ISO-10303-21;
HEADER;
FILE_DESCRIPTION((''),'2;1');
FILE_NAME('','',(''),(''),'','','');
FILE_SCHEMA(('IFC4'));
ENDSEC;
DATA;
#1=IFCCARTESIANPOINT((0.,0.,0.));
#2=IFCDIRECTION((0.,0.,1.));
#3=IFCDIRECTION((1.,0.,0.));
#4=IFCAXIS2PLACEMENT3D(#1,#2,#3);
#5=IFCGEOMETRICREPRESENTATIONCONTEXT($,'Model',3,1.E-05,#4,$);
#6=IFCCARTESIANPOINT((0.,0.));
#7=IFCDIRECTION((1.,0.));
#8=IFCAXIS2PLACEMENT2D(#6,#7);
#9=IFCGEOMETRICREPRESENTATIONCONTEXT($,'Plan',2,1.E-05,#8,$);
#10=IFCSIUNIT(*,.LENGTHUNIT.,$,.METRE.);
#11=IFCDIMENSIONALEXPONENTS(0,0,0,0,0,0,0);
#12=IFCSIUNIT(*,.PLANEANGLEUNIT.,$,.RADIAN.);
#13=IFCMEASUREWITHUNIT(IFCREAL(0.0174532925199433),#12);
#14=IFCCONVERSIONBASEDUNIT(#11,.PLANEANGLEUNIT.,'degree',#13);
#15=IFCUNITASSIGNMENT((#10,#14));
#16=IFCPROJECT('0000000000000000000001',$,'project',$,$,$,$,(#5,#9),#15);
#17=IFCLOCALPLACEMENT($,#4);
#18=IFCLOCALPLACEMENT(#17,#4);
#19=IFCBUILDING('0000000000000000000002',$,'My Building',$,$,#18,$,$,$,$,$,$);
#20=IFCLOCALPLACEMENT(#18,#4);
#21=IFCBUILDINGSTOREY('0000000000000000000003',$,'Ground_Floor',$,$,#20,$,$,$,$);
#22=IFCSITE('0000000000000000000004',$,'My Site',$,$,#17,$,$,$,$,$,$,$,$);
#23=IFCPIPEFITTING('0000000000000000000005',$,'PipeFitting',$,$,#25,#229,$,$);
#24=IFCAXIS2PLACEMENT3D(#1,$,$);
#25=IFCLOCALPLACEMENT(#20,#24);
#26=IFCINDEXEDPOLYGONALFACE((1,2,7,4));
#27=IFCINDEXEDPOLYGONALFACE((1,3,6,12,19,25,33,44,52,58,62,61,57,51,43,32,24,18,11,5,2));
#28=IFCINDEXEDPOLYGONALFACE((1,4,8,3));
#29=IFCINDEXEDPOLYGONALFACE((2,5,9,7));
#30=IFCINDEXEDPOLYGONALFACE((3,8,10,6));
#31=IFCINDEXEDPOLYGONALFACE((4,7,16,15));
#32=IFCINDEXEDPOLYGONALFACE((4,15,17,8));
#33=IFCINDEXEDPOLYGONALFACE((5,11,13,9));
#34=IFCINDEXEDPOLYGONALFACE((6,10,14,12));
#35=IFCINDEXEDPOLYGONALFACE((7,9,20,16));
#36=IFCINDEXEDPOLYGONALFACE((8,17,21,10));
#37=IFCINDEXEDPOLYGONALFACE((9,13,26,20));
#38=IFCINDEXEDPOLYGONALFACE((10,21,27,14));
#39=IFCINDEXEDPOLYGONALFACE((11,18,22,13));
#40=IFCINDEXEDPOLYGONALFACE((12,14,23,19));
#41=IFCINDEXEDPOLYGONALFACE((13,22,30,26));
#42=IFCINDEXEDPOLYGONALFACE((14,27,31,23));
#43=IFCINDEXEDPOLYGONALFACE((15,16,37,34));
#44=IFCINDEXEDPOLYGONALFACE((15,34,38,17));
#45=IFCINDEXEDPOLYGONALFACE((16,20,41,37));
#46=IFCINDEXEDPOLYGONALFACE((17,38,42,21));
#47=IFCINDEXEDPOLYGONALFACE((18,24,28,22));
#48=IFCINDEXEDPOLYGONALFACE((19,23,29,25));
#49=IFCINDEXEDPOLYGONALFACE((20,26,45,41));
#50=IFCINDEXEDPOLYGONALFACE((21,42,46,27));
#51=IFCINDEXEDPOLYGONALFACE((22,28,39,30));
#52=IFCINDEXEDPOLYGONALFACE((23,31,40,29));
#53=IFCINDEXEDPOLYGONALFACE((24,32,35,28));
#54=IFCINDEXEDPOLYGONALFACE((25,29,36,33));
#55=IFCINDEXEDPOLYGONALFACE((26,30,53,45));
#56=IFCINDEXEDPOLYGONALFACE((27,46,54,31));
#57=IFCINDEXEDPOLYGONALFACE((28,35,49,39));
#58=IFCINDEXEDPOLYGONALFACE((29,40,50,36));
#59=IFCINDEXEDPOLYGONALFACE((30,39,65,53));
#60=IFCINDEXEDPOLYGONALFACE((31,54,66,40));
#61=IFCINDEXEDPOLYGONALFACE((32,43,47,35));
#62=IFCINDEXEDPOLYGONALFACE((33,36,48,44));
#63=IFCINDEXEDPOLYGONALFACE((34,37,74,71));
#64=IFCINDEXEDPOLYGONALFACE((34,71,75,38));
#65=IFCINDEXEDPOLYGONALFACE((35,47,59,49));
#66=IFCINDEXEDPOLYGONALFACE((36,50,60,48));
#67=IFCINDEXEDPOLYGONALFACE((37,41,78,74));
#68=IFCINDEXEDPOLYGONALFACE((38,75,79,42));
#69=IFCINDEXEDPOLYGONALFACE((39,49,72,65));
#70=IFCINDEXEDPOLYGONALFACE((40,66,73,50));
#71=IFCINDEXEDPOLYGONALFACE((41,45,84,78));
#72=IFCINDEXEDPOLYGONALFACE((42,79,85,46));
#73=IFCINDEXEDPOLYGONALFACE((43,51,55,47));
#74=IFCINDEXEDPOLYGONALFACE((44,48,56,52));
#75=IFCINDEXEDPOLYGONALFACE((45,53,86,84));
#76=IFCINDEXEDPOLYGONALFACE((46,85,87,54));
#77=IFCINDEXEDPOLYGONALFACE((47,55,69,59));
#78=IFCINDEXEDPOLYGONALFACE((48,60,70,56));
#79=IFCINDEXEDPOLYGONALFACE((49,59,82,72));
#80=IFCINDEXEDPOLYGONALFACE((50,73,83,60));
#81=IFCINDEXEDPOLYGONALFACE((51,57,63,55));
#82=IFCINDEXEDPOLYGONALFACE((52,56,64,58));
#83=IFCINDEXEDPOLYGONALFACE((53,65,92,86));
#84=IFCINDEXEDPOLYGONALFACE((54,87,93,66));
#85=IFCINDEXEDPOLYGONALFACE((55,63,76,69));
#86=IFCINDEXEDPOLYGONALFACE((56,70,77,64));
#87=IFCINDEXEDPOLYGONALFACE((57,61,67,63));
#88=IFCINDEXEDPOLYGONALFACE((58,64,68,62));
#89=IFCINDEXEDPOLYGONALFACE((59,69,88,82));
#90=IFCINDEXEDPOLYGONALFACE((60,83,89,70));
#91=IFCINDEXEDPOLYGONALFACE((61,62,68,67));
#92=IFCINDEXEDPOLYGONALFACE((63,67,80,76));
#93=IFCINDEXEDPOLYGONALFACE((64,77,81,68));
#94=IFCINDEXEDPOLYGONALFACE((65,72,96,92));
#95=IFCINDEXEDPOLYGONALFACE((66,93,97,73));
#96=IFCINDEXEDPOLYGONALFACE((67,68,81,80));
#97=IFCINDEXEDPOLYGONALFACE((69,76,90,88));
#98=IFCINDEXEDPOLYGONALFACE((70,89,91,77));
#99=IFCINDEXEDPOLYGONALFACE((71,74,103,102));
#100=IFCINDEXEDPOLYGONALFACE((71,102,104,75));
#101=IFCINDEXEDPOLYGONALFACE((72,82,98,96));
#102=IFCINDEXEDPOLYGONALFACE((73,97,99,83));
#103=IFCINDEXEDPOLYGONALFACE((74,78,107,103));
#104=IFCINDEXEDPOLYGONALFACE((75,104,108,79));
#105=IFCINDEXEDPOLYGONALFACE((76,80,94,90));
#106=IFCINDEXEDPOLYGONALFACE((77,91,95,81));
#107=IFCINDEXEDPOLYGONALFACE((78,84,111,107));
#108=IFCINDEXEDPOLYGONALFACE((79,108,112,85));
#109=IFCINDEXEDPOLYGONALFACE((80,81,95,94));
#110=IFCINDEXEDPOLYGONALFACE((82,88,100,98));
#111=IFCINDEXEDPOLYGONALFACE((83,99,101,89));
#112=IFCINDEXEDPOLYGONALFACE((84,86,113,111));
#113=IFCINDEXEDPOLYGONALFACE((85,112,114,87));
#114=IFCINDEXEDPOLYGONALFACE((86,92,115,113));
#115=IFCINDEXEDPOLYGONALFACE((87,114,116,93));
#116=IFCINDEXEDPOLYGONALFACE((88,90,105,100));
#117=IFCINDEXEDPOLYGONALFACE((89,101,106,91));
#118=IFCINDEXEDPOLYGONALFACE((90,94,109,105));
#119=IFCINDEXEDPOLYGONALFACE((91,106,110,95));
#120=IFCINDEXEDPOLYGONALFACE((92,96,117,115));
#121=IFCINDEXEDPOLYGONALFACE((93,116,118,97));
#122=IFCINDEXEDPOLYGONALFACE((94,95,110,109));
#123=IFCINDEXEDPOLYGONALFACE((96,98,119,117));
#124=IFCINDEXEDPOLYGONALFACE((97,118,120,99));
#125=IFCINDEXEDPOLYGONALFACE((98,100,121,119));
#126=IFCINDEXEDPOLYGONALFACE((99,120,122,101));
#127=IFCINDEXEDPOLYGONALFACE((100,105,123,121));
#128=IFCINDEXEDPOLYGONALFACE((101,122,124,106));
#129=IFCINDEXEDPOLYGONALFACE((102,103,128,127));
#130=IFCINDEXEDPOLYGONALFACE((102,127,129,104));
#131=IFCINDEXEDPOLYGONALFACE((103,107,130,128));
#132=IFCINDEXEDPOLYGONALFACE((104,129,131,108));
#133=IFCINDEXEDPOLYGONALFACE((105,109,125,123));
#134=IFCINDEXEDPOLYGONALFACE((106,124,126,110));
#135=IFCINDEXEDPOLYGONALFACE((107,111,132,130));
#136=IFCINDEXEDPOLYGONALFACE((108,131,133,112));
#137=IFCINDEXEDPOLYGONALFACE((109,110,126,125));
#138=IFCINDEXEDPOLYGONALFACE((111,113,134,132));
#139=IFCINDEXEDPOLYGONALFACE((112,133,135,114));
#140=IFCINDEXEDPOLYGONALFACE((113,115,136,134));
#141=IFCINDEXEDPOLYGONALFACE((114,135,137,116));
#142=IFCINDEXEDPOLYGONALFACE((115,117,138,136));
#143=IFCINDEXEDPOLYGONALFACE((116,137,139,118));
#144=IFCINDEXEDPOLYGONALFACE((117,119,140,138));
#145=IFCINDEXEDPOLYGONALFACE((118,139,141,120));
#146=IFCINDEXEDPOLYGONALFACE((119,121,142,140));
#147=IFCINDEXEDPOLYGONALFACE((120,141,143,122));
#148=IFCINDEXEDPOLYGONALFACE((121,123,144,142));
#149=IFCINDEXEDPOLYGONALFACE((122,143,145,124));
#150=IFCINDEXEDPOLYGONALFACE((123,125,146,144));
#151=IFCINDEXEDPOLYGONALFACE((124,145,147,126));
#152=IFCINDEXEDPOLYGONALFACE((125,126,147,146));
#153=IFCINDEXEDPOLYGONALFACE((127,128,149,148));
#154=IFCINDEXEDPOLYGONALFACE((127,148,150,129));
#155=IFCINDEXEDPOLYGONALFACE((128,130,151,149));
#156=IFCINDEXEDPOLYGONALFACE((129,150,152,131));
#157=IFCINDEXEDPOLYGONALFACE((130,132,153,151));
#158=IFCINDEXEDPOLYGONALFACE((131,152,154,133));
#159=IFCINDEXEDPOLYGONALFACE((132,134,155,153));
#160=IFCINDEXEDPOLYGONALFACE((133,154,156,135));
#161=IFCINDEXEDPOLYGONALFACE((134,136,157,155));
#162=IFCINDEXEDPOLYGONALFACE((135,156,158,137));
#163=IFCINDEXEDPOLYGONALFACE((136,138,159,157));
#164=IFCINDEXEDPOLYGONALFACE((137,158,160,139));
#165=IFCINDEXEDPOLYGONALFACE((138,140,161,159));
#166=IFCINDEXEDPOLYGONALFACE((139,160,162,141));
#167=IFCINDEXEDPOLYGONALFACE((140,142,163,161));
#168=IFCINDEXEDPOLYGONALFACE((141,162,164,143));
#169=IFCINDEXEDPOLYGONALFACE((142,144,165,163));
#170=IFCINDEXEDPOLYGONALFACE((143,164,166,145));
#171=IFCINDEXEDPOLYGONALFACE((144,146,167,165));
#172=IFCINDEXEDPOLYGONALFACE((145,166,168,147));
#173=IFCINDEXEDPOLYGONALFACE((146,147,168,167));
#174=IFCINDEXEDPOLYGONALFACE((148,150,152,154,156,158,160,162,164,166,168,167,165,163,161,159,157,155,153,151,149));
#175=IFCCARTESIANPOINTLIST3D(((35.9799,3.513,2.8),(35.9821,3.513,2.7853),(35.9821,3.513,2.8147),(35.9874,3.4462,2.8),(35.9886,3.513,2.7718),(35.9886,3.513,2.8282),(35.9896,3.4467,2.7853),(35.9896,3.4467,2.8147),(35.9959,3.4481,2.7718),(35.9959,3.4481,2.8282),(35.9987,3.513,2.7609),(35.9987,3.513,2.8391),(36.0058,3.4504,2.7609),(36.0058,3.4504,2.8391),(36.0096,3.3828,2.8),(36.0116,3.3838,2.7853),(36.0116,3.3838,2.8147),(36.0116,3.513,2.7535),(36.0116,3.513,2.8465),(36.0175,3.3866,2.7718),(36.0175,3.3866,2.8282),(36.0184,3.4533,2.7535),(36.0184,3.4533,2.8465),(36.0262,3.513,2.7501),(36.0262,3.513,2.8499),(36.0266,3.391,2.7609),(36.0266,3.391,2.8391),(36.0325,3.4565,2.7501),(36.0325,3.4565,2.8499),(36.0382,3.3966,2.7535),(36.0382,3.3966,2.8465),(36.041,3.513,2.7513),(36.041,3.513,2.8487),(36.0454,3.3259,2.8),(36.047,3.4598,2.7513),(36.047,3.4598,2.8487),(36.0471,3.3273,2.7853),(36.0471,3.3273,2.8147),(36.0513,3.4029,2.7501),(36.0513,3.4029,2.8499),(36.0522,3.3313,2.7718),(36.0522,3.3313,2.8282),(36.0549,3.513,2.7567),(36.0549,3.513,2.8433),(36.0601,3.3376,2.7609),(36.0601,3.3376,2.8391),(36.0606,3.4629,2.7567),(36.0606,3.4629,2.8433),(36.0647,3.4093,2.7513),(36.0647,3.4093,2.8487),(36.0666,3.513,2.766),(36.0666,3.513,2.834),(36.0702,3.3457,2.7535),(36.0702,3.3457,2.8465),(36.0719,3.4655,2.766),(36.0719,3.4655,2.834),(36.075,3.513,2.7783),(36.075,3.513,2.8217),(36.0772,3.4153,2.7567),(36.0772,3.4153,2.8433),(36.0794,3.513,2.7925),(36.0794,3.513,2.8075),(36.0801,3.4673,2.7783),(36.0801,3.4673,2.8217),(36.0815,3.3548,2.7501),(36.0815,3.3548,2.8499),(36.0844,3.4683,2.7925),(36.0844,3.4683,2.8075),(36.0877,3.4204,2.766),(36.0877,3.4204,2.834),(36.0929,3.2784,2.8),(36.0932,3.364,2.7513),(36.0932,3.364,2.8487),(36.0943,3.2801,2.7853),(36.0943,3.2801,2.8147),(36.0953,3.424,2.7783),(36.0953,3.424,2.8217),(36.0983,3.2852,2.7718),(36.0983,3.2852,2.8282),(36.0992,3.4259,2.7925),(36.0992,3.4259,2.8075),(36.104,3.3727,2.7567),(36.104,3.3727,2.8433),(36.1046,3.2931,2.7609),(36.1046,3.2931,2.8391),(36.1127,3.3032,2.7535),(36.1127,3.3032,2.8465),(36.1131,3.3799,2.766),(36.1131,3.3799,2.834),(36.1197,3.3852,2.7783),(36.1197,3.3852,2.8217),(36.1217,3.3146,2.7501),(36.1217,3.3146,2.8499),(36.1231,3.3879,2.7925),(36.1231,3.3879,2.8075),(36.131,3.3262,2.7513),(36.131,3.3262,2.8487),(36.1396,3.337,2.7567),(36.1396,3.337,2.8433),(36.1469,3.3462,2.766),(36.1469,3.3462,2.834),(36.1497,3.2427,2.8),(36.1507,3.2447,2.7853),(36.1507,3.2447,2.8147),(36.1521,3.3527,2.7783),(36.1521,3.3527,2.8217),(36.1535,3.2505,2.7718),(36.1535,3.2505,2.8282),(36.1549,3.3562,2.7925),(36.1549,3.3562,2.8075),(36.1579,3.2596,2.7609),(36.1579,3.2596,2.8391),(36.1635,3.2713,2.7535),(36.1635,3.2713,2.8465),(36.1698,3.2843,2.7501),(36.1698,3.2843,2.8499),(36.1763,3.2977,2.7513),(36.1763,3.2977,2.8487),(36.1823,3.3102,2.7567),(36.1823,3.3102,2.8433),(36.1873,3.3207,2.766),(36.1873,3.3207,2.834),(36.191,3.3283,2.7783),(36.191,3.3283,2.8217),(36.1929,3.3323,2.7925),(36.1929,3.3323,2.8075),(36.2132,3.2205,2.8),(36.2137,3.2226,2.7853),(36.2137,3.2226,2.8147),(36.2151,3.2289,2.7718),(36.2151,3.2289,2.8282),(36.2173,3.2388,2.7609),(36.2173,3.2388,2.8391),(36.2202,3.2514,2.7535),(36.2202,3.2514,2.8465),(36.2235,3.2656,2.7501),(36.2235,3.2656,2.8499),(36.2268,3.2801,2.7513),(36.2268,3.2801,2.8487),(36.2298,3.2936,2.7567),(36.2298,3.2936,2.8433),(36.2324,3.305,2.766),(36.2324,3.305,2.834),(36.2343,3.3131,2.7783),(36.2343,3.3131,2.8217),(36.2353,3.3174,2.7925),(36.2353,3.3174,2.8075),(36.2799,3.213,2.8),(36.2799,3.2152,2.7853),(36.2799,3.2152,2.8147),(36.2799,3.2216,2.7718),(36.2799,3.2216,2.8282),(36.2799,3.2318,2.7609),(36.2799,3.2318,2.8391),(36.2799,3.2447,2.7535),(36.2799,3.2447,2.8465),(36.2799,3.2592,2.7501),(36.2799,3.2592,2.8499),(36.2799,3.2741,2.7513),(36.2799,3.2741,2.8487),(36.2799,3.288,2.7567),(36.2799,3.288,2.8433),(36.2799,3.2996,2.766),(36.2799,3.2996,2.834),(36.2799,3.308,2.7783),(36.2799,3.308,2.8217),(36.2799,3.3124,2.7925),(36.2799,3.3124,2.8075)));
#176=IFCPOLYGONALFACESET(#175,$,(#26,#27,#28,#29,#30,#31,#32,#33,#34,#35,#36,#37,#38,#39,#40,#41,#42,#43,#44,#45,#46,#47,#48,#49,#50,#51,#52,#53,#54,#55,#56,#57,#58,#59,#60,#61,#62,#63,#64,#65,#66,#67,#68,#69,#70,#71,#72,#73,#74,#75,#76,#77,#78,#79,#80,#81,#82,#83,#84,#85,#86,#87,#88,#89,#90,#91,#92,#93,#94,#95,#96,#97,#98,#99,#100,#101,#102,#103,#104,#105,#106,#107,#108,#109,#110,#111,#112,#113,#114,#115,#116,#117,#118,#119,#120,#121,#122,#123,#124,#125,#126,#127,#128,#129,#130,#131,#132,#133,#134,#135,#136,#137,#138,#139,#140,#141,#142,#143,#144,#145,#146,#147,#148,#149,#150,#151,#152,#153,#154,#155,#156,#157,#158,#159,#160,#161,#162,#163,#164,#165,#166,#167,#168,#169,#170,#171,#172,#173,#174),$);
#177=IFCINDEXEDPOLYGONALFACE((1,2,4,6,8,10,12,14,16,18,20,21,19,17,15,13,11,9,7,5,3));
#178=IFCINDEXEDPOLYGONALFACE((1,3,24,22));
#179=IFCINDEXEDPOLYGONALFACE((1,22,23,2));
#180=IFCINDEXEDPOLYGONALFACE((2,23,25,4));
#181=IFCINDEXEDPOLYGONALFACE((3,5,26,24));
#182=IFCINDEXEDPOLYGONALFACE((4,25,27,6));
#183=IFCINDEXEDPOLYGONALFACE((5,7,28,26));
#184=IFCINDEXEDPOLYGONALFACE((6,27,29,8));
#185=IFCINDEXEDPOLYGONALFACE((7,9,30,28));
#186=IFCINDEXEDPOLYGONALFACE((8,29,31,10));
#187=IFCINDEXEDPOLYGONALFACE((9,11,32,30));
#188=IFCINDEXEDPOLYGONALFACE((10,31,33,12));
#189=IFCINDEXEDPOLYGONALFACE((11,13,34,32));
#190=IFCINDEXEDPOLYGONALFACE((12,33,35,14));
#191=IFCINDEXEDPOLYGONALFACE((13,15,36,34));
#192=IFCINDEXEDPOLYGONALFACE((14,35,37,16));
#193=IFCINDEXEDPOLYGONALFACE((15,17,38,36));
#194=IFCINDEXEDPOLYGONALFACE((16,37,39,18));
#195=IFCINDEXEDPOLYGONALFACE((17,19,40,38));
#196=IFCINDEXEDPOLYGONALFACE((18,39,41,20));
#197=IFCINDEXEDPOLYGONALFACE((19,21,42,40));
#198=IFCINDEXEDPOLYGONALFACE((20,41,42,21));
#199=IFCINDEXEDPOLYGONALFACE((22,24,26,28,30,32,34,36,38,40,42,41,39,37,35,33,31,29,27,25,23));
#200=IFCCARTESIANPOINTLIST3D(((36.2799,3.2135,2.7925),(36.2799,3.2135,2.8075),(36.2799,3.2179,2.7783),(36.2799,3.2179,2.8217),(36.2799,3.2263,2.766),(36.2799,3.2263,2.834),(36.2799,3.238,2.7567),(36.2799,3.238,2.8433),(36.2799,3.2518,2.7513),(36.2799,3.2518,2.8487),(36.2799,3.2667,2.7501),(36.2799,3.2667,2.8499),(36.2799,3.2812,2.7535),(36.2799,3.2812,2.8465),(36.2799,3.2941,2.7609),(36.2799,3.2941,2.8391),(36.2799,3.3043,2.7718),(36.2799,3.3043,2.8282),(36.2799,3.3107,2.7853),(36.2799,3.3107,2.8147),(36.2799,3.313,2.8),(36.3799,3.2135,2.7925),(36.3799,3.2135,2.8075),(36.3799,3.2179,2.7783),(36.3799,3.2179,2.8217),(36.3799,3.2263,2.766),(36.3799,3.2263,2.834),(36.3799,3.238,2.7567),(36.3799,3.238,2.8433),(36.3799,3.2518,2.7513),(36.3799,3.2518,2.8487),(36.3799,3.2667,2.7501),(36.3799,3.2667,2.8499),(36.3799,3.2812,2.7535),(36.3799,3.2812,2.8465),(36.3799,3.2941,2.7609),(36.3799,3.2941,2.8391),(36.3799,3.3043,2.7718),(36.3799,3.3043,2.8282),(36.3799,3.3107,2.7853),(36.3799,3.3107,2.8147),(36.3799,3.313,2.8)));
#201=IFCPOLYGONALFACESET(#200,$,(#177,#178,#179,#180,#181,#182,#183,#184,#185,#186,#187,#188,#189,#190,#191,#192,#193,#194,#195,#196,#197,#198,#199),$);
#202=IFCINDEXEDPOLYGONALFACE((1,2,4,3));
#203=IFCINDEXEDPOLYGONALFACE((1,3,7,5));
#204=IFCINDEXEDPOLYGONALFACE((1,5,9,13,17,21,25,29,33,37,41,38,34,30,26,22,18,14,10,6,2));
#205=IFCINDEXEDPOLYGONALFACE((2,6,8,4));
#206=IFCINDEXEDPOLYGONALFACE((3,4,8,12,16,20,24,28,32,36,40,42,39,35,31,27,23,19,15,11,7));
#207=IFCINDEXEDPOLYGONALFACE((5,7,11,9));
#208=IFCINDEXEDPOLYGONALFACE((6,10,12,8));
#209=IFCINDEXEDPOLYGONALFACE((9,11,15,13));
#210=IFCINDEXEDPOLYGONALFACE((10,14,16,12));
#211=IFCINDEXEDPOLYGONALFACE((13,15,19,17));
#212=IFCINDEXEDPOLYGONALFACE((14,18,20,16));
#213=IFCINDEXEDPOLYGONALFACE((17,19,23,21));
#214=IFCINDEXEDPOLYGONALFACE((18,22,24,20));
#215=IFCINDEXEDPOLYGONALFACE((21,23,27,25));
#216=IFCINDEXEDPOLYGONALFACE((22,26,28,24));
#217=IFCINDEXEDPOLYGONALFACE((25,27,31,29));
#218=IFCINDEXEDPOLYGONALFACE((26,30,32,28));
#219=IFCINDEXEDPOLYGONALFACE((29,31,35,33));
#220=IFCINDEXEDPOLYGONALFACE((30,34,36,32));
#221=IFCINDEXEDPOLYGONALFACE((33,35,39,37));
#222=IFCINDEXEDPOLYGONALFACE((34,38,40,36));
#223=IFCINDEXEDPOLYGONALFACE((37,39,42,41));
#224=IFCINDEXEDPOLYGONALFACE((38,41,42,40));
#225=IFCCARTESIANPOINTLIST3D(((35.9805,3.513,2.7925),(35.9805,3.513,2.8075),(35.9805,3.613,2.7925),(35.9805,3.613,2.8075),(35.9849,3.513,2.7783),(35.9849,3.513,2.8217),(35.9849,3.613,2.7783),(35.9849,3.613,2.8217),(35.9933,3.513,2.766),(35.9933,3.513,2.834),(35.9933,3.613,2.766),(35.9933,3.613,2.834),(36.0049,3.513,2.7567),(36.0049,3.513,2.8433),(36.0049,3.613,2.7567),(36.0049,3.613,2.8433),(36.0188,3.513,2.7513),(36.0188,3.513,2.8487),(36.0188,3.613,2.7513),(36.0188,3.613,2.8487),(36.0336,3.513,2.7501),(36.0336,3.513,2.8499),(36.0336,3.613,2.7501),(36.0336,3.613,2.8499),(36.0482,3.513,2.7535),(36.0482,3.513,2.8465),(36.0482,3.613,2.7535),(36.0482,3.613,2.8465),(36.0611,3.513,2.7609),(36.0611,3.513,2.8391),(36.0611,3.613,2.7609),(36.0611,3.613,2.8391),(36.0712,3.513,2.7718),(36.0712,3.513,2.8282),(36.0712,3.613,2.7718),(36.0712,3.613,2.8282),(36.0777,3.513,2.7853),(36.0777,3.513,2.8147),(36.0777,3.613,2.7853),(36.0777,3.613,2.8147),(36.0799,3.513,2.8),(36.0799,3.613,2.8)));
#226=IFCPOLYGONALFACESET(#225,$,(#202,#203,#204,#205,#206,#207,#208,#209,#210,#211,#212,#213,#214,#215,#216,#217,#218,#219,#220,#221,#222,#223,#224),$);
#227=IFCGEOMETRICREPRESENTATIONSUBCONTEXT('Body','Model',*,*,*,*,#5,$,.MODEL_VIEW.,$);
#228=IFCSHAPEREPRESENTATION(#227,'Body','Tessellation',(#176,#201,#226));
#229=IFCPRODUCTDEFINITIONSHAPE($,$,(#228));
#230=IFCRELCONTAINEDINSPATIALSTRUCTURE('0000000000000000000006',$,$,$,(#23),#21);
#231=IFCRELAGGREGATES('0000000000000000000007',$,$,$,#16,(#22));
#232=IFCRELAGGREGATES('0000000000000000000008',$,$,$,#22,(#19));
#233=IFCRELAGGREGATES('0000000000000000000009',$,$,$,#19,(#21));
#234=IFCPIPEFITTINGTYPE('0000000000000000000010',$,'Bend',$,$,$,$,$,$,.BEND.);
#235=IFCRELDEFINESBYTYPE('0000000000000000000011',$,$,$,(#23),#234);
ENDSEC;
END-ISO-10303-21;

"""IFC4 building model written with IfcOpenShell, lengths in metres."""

from ifc_helpers import new_model, entity, si_unit, converted_unit, frame, origin_with_axes, origin_2d_with_axis, place, context, subcontext, project, spatial, circle, extrude, source, transform, mapped, type_object, type_shapes, element, save


model = new_model("IFC4")

# Units and contexts
model_context = context("Model", 3, precision=1e-05, world=origin_with_axes())
plan_context = context("Plan", 2, precision=1e-05, world=origin_2d_with_axis())
body_context = subcontext(model_context, "Body", "Model", "MODEL_VIEW")
ifc_project = project(units=[si_unit("LENGTHUNIT", "METRE"), converted_unit("PLANEANGLEUNIT", "degree", entity("IfcReal", 0.0174532925199433), si_unit("PLANEANGLEUNIT", "RADIAN"), dimensions=[0, 0, 0, 0, 0, 0, 0])], contexts=[model_context, plan_context])

# Site, building, storey
site_placement = place(None, origin_with_axes())
site = spatial("IfcSite", under=ifc_project, at=site_placement, Name="My Site")
building_placement = place(site_placement, origin_with_axes())
building = spatial("IfcBuilding", under=site, at=building_placement, Name="My Building")
storey_placement = place(building_placement, origin_with_axes())
storey = spatial("IfcBuildingStorey", under=building, at=storey_placement, Name="Ground_Floor")

# Pipe fitting
pipe_fitting_type = type_object("IfcPipeFittingType", Name="Bend", PredefinedType="BEND")
shared_shape = source(origin_with_axes(), body_context, "Body", "SolidModel", [
    entity("IfcSweptDiskSolid", entity("IfcIndexedPolyCurve", entity("IfcCartesianPointList3D", [[0.0, 0.0, -0.1], [0.0732, 0.0, -0.2768], [0.25, 0.0, -0.35]]), [entity("IfcArcIndex", [1, 2, 3])]), 0.05),
    extrude(circle(Radius=0.05), origin_with_axes(), (0.0, 0.0, -1.0), 0.1),
    extrude(circle(Radius=0.05), frame((0.25, 0.0, -0.35), z_axis=(1.0, 0.0, 0.0), x_axis=(0.0, 0.0, 1.0)), (0.0, 0.0, 1.0), 0.1),
])
type_shapes(pipe_fitting_type, [shared_shape])
for number, where, z_axis, x_axis, name in (
    (1, (36.3799, 3.263, 2.8), (1.0, 0.0, 0.0), (0.0, 1.0, 0.0), "PipeFitting"),
):
    element("IfcPipeFitting", number, at=place(storey_placement, frame(where, z_axis=z_axis, x_axis=x_axis)), inside=storey, type_object=pipe_fitting_type, Name=name, context=body_context, shape_type="MappedRepresentation", body=[
        mapped(shared_shape, transform((0.0, 0.0, 0.0), x_axis=(1.0, 0.0, 0.0), y_axis=(0.0, 1.0, 0.0), z_axis=(0.0, 0.0, 1.0), scale=1.0)),
    ])

save(model, "model.ifc")
